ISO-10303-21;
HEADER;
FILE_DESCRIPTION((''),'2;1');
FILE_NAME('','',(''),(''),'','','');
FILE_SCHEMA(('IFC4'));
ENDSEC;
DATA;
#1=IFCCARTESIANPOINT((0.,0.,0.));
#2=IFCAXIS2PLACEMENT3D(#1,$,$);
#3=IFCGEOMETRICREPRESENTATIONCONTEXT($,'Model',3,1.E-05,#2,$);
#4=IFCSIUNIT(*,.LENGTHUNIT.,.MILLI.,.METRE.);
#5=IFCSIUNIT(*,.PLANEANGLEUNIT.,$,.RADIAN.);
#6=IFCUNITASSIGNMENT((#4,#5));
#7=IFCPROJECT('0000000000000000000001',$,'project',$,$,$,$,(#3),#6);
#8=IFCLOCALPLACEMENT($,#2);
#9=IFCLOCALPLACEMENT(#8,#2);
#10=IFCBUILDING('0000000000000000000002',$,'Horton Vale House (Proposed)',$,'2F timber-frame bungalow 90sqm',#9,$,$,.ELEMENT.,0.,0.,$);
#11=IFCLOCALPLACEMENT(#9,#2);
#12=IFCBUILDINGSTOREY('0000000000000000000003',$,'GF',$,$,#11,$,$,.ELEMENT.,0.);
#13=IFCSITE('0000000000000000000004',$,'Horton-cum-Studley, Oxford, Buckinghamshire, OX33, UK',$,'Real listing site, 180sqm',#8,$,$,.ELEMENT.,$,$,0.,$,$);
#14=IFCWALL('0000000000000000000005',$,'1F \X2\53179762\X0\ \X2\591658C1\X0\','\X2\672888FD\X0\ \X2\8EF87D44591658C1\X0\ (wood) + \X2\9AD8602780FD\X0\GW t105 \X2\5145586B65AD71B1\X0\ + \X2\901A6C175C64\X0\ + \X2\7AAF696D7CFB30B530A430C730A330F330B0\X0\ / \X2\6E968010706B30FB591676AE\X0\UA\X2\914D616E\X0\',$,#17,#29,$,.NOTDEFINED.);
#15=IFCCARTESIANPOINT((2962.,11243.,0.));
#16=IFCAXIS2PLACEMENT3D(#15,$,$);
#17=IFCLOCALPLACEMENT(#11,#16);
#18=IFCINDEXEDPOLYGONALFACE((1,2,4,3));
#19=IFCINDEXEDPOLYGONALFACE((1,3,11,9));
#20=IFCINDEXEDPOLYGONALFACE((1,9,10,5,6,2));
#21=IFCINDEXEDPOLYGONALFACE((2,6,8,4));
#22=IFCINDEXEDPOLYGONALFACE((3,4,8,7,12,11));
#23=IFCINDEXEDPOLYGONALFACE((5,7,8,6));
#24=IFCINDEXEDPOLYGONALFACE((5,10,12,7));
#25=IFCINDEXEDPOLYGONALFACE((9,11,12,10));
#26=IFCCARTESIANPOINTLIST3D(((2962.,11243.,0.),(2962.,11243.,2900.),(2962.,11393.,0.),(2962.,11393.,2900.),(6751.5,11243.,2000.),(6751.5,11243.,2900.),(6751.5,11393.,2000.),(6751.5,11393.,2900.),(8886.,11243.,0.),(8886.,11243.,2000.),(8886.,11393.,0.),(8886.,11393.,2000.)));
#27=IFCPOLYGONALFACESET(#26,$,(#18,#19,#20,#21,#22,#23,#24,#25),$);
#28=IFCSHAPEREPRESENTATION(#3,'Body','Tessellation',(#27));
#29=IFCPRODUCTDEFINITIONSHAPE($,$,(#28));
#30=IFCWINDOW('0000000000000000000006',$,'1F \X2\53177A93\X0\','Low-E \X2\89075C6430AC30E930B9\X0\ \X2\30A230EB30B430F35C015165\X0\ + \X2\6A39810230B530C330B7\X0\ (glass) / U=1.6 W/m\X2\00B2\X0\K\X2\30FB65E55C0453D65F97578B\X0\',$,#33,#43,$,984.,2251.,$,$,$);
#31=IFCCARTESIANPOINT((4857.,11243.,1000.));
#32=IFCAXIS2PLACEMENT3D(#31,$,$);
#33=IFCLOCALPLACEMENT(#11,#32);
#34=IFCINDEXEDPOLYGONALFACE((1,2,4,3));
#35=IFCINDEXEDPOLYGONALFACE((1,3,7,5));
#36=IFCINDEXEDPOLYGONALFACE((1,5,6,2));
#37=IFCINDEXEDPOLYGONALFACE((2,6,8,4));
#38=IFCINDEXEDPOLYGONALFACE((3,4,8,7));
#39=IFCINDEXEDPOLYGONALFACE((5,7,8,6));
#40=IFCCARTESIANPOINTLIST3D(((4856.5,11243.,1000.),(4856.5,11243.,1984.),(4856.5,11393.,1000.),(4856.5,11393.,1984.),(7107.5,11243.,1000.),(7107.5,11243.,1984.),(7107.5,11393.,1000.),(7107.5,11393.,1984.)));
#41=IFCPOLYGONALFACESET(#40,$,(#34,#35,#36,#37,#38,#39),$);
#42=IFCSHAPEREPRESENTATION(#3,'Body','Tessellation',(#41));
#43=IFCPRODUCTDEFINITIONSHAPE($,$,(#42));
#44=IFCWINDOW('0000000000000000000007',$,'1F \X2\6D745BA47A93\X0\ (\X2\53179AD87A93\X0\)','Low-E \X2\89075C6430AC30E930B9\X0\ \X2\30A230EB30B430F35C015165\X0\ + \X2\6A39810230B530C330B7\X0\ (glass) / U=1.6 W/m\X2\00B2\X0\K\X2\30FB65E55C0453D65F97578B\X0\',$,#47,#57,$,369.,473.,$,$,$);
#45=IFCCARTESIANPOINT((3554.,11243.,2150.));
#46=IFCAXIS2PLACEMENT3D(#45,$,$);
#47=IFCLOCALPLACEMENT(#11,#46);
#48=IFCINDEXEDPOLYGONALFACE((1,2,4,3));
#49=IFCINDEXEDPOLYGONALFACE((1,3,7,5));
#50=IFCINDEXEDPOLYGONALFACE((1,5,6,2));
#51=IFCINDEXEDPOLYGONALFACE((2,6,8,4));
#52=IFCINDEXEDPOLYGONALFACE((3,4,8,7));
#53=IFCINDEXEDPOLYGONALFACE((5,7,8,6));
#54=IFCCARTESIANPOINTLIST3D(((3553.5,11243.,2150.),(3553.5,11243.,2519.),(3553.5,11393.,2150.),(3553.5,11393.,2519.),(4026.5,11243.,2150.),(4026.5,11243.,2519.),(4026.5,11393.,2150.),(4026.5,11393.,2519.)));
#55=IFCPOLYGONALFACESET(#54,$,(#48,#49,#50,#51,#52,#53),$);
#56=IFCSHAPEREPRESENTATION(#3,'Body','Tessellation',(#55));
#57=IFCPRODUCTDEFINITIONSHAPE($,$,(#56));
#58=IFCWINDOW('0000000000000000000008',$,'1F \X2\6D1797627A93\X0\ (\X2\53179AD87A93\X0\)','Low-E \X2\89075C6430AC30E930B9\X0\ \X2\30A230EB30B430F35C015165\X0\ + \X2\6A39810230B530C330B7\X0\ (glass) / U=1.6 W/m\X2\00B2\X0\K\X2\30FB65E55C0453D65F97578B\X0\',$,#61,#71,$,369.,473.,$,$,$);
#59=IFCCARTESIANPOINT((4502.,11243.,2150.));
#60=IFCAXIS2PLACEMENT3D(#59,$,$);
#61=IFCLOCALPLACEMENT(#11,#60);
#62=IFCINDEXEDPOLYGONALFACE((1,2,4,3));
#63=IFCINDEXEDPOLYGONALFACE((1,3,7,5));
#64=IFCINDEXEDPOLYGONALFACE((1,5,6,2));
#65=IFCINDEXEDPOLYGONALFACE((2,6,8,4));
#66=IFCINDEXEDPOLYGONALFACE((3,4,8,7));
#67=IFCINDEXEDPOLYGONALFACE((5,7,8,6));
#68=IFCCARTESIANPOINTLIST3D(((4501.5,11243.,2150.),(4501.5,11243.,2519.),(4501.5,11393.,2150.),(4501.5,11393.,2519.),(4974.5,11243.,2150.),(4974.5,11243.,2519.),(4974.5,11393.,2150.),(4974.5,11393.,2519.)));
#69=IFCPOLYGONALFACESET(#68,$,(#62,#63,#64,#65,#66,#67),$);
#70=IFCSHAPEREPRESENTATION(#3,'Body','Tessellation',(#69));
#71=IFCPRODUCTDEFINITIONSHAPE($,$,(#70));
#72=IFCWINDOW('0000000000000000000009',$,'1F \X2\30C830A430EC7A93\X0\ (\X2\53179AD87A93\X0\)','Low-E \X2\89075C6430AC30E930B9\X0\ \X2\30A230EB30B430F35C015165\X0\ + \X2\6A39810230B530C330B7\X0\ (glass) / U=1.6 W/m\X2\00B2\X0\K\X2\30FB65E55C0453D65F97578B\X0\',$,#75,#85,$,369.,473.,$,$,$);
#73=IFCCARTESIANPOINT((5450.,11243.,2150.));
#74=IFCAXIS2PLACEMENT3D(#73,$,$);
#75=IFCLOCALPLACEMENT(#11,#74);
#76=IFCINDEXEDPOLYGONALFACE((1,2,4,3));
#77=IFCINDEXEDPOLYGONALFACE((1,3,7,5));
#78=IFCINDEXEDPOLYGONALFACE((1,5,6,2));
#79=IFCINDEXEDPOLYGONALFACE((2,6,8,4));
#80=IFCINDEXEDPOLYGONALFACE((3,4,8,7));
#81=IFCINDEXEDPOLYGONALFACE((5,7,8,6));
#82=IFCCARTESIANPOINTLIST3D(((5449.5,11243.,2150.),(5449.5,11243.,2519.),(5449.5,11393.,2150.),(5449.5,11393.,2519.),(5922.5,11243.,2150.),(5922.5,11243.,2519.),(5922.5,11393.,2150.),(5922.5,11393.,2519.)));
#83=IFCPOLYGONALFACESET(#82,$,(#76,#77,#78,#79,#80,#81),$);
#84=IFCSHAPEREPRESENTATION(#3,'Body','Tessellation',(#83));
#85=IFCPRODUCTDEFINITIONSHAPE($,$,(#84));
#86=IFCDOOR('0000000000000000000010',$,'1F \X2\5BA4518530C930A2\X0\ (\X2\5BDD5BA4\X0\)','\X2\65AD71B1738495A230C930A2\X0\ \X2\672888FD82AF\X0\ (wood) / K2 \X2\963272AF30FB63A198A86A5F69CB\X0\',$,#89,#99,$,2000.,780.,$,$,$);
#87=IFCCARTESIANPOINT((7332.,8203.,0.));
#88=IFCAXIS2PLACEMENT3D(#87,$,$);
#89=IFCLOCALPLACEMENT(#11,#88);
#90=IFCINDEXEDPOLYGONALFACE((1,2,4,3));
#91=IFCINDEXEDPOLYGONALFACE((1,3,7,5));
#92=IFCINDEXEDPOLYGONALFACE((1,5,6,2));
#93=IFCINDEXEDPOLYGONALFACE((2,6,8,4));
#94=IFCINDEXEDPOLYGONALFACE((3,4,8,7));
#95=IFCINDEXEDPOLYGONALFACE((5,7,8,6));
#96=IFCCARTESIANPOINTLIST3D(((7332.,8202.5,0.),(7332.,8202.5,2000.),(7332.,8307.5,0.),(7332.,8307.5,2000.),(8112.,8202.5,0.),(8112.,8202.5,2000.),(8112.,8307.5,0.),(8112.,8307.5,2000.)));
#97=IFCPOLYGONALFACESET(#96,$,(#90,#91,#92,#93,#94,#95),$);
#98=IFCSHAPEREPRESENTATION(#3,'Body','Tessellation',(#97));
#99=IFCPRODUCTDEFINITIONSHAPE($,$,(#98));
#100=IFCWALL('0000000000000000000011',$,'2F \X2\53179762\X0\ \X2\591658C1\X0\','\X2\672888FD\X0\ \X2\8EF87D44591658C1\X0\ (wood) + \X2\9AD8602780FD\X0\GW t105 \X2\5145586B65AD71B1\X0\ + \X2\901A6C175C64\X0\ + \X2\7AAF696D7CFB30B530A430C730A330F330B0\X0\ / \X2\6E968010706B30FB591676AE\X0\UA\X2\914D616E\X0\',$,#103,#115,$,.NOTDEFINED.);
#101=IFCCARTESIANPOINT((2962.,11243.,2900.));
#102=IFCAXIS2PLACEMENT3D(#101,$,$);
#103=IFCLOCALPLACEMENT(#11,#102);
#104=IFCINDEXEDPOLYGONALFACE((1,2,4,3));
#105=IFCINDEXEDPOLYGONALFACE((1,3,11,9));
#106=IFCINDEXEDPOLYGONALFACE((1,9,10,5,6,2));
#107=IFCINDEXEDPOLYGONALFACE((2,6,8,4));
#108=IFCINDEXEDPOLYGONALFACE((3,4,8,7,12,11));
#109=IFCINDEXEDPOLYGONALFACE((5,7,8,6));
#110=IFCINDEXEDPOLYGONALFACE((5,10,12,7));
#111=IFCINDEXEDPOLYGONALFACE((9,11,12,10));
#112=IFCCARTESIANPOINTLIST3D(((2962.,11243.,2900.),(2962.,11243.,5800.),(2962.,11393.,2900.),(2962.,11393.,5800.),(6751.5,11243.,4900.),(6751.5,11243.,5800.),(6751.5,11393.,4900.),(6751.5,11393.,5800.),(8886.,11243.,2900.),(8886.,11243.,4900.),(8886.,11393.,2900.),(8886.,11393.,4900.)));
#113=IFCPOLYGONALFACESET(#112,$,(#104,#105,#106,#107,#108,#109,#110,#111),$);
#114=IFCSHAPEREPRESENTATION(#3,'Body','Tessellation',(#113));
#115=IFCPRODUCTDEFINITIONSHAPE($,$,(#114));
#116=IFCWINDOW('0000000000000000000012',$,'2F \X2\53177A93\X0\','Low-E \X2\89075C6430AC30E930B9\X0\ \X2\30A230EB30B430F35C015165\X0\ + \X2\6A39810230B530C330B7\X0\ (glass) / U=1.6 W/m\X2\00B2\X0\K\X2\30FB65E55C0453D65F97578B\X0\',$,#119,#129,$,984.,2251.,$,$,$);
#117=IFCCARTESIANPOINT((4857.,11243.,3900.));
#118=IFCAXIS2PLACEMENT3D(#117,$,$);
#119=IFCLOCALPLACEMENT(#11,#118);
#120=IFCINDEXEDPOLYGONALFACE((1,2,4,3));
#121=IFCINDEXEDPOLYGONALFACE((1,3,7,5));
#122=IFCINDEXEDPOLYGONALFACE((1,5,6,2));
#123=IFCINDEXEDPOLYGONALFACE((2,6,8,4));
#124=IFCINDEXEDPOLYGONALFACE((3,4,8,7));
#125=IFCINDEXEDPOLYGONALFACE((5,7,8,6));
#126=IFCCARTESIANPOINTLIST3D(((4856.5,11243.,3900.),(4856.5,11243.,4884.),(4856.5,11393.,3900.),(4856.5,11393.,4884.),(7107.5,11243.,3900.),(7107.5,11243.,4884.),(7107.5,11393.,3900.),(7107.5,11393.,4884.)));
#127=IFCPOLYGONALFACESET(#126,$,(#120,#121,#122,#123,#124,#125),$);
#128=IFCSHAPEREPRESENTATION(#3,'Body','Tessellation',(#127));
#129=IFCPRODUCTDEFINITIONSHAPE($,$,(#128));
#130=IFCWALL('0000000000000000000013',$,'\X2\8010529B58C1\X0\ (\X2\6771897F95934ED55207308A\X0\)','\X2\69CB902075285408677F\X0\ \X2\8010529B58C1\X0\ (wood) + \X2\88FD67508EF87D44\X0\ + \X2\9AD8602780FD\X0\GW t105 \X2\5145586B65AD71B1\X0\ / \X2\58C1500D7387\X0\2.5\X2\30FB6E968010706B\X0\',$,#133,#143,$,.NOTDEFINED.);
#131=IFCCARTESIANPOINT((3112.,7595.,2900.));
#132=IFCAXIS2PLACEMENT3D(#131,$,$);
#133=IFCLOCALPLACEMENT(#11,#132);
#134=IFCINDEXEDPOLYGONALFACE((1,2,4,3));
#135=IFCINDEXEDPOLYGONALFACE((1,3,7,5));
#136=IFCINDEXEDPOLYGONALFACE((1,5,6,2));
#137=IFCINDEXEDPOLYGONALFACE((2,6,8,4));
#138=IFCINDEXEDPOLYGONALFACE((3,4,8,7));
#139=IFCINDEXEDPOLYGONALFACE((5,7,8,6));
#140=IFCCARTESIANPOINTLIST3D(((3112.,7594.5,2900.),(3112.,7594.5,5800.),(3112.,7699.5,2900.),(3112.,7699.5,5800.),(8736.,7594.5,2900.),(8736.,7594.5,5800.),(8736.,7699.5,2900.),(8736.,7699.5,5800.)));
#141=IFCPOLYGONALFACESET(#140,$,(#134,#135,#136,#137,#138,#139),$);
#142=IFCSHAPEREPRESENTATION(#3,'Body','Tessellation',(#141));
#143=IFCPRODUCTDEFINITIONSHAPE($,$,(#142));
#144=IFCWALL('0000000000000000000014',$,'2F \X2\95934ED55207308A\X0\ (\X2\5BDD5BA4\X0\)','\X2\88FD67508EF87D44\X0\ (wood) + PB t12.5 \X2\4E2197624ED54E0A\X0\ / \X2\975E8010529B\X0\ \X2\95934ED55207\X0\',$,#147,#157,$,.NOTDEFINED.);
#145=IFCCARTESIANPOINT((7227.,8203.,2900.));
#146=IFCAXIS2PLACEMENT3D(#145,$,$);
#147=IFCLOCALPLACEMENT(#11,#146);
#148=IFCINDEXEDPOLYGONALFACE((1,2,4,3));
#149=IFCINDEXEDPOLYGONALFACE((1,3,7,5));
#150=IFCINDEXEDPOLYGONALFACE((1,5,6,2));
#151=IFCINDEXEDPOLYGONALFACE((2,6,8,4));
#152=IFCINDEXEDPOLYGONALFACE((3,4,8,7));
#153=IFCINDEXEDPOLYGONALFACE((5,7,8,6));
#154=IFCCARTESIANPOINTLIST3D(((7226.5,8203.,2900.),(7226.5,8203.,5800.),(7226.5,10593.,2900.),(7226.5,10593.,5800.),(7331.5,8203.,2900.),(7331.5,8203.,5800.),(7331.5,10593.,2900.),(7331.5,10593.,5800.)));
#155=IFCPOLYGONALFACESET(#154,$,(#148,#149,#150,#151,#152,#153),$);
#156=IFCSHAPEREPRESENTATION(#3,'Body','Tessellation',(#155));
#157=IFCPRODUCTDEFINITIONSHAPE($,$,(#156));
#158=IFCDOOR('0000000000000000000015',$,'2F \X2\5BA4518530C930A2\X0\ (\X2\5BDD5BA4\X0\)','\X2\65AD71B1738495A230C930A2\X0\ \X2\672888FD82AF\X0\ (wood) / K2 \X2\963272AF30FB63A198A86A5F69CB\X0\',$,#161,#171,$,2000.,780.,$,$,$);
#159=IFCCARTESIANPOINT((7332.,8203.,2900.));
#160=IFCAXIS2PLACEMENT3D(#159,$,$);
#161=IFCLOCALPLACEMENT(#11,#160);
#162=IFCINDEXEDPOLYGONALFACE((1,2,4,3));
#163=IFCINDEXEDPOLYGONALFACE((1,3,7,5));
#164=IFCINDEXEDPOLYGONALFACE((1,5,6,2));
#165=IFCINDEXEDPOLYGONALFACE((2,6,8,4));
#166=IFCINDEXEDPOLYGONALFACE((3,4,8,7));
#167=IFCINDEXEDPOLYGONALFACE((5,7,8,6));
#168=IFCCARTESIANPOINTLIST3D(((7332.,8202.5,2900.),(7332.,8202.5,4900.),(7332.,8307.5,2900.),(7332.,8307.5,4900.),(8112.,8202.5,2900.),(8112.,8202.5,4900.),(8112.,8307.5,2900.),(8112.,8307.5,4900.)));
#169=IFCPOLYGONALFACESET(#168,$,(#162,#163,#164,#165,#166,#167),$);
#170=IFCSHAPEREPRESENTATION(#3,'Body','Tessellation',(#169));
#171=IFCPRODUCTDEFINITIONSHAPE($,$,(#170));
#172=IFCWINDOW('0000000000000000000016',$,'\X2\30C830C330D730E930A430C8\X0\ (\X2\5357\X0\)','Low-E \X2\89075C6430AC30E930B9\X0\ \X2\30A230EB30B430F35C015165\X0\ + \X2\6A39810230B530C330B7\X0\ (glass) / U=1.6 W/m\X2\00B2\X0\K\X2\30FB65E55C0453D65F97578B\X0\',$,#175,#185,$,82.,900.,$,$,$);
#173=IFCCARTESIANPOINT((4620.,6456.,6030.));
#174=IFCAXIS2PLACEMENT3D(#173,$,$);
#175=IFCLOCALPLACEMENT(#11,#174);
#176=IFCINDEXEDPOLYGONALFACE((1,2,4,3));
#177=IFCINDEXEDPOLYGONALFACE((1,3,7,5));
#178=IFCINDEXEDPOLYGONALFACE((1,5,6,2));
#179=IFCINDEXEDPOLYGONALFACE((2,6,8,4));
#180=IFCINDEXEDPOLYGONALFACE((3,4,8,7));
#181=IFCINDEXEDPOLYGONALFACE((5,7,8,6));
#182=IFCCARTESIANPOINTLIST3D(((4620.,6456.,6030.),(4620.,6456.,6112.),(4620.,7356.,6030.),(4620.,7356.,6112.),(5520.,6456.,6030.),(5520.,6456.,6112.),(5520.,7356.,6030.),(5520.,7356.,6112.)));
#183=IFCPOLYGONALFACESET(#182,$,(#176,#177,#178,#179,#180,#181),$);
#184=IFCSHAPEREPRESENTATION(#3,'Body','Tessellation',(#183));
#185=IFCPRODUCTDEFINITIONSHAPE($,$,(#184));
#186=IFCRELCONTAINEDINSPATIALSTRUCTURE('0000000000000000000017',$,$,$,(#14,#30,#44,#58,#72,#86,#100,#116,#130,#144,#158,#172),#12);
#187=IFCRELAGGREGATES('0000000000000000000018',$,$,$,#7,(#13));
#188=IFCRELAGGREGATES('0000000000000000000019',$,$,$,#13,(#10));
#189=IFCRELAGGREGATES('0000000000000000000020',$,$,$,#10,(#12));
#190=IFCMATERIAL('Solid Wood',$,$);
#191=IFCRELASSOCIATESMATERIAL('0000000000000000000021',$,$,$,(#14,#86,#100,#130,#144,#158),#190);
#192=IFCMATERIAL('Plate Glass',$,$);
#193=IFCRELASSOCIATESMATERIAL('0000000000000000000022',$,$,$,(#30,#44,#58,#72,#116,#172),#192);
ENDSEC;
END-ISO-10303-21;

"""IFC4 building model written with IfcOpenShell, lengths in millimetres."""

from ifc_helpers import new_model, si_unit, frame, frame_2d, origin, place, context, project, spatial, rectangle, extrude, material, element, fill, save


model = new_model("IFC4")

# Units and contexts
model_context = context("Model", 3, precision=1e-05, world=origin())
ifc_project = project(units=[si_unit("LENGTHUNIT", "METRE", prefix="MILLI"), si_unit("PLANEANGLEUNIT", "RADIAN")], contexts=[model_context])

# Site, building, storey
site_placement = place(None, origin())
site = spatial("IfcSite", under=ifc_project, at=site_placement, Name="Horton-cum-Studley, Oxford, Buckinghamshire, OX33, UK", ObjectType="Real listing site, 180sqm", CompositionType="ELEMENT", RefElevation=0.0)
building_placement = place(site_placement, origin())
building = spatial("IfcBuilding", under=site, at=building_placement, Name="Horton Vale House (Proposed)", ObjectType="2F timber-frame bungalow 90sqm", CompositionType="ELEMENT", ElevationOfRefHeight=0.0, ElevationOfTerrain=0.0)
storey_placement = place(building_placement, origin())
storey = spatial("IfcBuildingStorey", under=building, at=storey_placement, Name="GF", CompositionType="ELEMENT", Elevation=0.0)

# Wall, openings, windows
ifc_material_1 = material(Name="Solid Wood")
wall_1_placement = place(storey_placement, frame((2962.0, 11243.0, 0.0)))
wall_1 = element("IfcWall", 1, at=wall_1_placement, inside=storey, material=ifc_material_1, Name="1F 北面 外壁", Description="木製 軸組外壁 (wood) + 高性能GW t105 充填断熱 + 通気層 + 窯業系サイディング / 準耐火・外皮UA配慮", PredefinedType="NOTDEFINED", context=model_context, shape_type="SweptSolid", body=[
    extrude(rectangle(XDim=5924.0, YDim=150.0, at=frame_2d((2962.0, 75.0))), frame((2962.0, 11243.0, 0.0)), (0.0, 0.0, 1.0), 2900.0),
])
opening_1_placement = place(storey_placement, frame((4857.0, 11243.0, 1000.0)))
opening_1 = element("IfcOpeningElement", 2, at=opening_1_placement, cuts=wall_1, PredefinedType="NOTDEFINED", context=model_context, shape_type="SweptSolid", body=[
    extrude(rectangle(XDim=2251.0, YDim=150.0, at=frame_2d((1125.0, 75.0))), frame((4857.0, 11243.0, 1000.0)), (0.0, 0.0, 1.0), 984.0),
])
opening_2_placement = place(storey_placement, frame((3554.0, 11243.0, 2150.0)))
opening_2 = element("IfcOpeningElement", 3, at=opening_2_placement, cuts=wall_1, PredefinedType="NOTDEFINED", context=model_context, shape_type="SweptSolid", body=[
    extrude(rectangle(XDim=473.0, YDim=150.0, at=frame_2d((236.0, 75.0))), frame((3554.0, 11243.0, 2150.0)), (0.0, 0.0, 1.0), 369.0),
])
opening_3_placement = place(storey_placement, frame((4502.0, 11243.0, 2150.0)))
opening_3 = element("IfcOpeningElement", 4, at=opening_3_placement, cuts=wall_1, PredefinedType="NOTDEFINED", context=model_context, shape_type="SweptSolid", body=[
    extrude(rectangle(XDim=473.0, YDim=150.0, at=frame_2d((236.0, 75.0))), frame((4502.0, 11243.0, 2150.0)), (0.0, 0.0, 1.0), 369.0),
])
opening_4_placement = place(storey_placement, frame((5450.0, 11243.0, 2150.0)))
opening_4 = element("IfcOpeningElement", 5, at=opening_4_placement, cuts=wall_1, PredefinedType="NOTDEFINED", context=model_context, shape_type="SweptSolid", body=[
    extrude(rectangle(XDim=473.0, YDim=150.0, at=frame_2d((236.0, 75.0))), frame((5450.0, 11243.0, 2150.0)), (0.0, 0.0, 1.0), 369.0),
])
ifc_material_2 = material(Name="Plate Glass")
window_1_placement = place(storey_placement, frame((4857.0, 11243.0, 1000.0)))
window_1 = element("IfcWindow", 6, at=window_1_placement, inside=storey, material=ifc_material_2, Name="1F 北窓", Description="Low-E 複層ガラス アルゴン封入 + 樹脂サッシ (glass) / U=1.6 W/m²K・日射取得型", OverallHeight=984.0, OverallWidth=2251.0, context=model_context, shape_type="SweptSolid", body=[
    extrude(rectangle(XDim=2251.0, YDim=150.0, at=frame_2d((1125.0, 75.0))), frame((4857.0, 11243.0, 1000.0)), (0.0, 0.0, 1.0), 984.0),
])
fill(opening_1, window_1)
window_2_placement = place(storey_placement, frame((3554.0, 11243.0, 2150.0)))
window_2 = element("IfcWindow", 7, at=window_2_placement, inside=storey, material=ifc_material_2, Name="1F 浴室窓 (北高窓)", Description="Low-E 複層ガラス アルゴン封入 + 樹脂サッシ (glass) / U=1.6 W/m²K・日射取得型", OverallHeight=369.0, OverallWidth=473.0, context=model_context, shape_type="SweptSolid", body=[
    extrude(rectangle(XDim=473.0, YDim=150.0, at=frame_2d((236.0, 75.0))), frame((3554.0, 11243.0, 2150.0)), (0.0, 0.0, 1.0), 369.0),
])
fill(opening_2, window_2)
window_3_placement = place(storey_placement, frame((4502.0, 11243.0, 2150.0)))
window_3 = element("IfcWindow", 8, at=window_3_placement, inside=storey, material=ifc_material_2, Name="1F 洗面窓 (北高窓)", Description="Low-E 複層ガラス アルゴン封入 + 樹脂サッシ (glass) / U=1.6 W/m²K・日射取得型", OverallHeight=369.0, OverallWidth=473.0, context=model_context, shape_type="SweptSolid", body=[
    extrude(rectangle(XDim=473.0, YDim=150.0, at=frame_2d((236.0, 75.0))), frame((4502.0, 11243.0, 2150.0)), (0.0, 0.0, 1.0), 369.0),
])
fill(opening_3, window_3)
window_4_placement = place(storey_placement, frame((5450.0, 11243.0, 2150.0)))
window_4 = element("IfcWindow", 9, at=window_4_placement, inside=storey, material=ifc_material_2, Name="1F トイレ窓 (北高窓)", Description="Low-E 複層ガラス アルゴン封入 + 樹脂サッシ (glass) / U=1.6 W/m²K・日射取得型", OverallHeight=369.0, OverallWidth=473.0, context=model_context, shape_type="SweptSolid", body=[
    extrude(rectangle(XDim=473.0, YDim=150.0, at=frame_2d((236.0, 75.0))), frame((5450.0, 11243.0, 2150.0)), (0.0, 0.0, 1.0), 369.0),
])
fill(opening_4, window_4)

# Door
door_1_placement = place(storey_placement, frame((7332.0, 8203.0, 0.0)))
element("IfcDoor", 10, at=door_1_placement, inside=storey, material=ifc_material_1, Name="1F 室内ドア (寝室)", Description="断熱玄関ドア 木製芯 (wood) / K2 防犯・採風機構", OverallHeight=2000.0, OverallWidth=780.0, context=model_context, shape_type="SweptSolid", body=[
    extrude(rectangle(XDim=780.0, YDim=105.0, at=frame_2d((390.0, 52.0))), frame((7332.0, 8203.0, 0.0)), (0.0, 0.0, 1.0), 2000.0),
])

# Wall, opening, window
wall_2_placement = place(storey_placement, frame((2962.0, 11243.0, 2900.0)))
wall_2 = element("IfcWall", 11, at=wall_2_placement, inside=storey, material=ifc_material_1, Name="2F 北面 外壁", Description="木製 軸組外壁 (wood) + 高性能GW t105 充填断熱 + 通気層 + 窯業系サイディング / 準耐火・外皮UA配慮", PredefinedType="NOTDEFINED", context=model_context, shape_type="SweptSolid", body=[
    extrude(rectangle(XDim=5924.0, YDim=150.0, at=frame_2d((2962.0, 75.0))), frame((2962.0, 11243.0, 2900.0)), (0.0, 0.0, 1.0), 2900.0),
])
opening_5_placement = place(storey_placement, frame((4857.0, 11243.0, 3900.0)))
opening_5 = element("IfcOpeningElement", 12, at=opening_5_placement, cuts=wall_2, PredefinedType="NOTDEFINED", context=model_context, shape_type="SweptSolid", body=[
    extrude(rectangle(XDim=2251.0, YDim=150.0, at=frame_2d((1125.0, 75.0))), frame((4857.0, 11243.0, 3900.0)), (0.0, 0.0, 1.0), 984.0),
])
window_5_placement = place(storey_placement, frame((4857.0, 11243.0, 3900.0)))
window_5 = element("IfcWindow", 13, at=window_5_placement, inside=storey, material=ifc_material_2, Name="2F 北窓", Description="Low-E 複層ガラス アルゴン封入 + 樹脂サッシ (glass) / U=1.6 W/m²K・日射取得型", OverallHeight=984.0, OverallWidth=2251.0, context=model_context, shape_type="SweptSolid", body=[
    extrude(rectangle(XDim=2251.0, YDim=150.0, at=frame_2d((1125.0, 75.0))), frame((4857.0, 11243.0, 3900.0)), (0.0, 0.0, 1.0), 984.0),
])
fill(opening_5, window_5)

# Walls
wall_3_placement = place(storey_placement, frame((3112.0, 7595.0, 2900.0)))
element("IfcWall", 14, at=wall_3_placement, inside=storey, material=ifc_material_1, Name="耐力壁 (東西間仕切り)", Description="構造用合板 耐力壁 (wood) + 製材軸組 + 高性能GW t105 充填断熱 / 壁倍率2.5・準耐火", PredefinedType="NOTDEFINED", context=model_context, shape_type="SweptSolid", body=[
    extrude(rectangle(XDim=5624.0, YDim=105.0, at=frame_2d((2812.0, 52.0))), frame((3112.0, 7595.0, 2900.0)), (0.0, 0.0, 1.0), 2900.0),
])
wall_4_placement = place(storey_placement, frame((7227.0, 8203.0, 2900.0)))
element("IfcWall", 15, at=wall_4_placement, inside=storey, material=ifc_material_1, Name="2F 間仕切り (寝室)", Description="製材軸組 (wood) + PB t12.5 両面仕上 / 非耐力 間仕切", PredefinedType="NOTDEFINED", context=model_context, shape_type="SweptSolid", body=[
    extrude(rectangle(XDim=105.0, YDim=2390.0, at=frame_2d((52.0, 1195.0))), frame((7227.0, 8203.0, 2900.0)), (0.0, 0.0, 1.0), 2900.0),
])

# Door
door_2_placement = place(storey_placement, frame((7332.0, 8203.0, 2900.0)))
element("IfcDoor", 16, at=door_2_placement, inside=storey, material=ifc_material_1, Name="2F 室内ドア (寝室)", Description="断熱玄関ドア 木製芯 (wood) / K2 防犯・採風機構", OverallHeight=2000.0, OverallWidth=780.0, context=model_context, shape_type="SweptSolid", body=[
    extrude(rectangle(XDim=780.0, YDim=105.0, at=frame_2d((390.0, 52.0))), frame((7332.0, 8203.0, 2900.0)), (0.0, 0.0, 1.0), 2000.0),
])

# Window
window_6_placement = place(storey_placement, frame((4620.0, 6456.0, 6030.0)))
element("IfcWindow", 17, at=window_6_placement, inside=storey, material=ifc_material_2, Name="トップライト (南)", Description="Low-E 複層ガラス アルゴン封入 + 樹脂サッシ (glass) / U=1.6 W/m²K・日射取得型", OverallHeight=82.0, OverallWidth=900.0, context=model_context, shape_type="SweptSolid", body=[
    extrude(rectangle(XDim=900.0, YDim=900.0, at=frame_2d((450.0, 450.0))), frame((4620.0, 6456.0, 6030.0)), (0.0, 0.0, 1.0), 82.0),
])

save(model, "model.ifc")
